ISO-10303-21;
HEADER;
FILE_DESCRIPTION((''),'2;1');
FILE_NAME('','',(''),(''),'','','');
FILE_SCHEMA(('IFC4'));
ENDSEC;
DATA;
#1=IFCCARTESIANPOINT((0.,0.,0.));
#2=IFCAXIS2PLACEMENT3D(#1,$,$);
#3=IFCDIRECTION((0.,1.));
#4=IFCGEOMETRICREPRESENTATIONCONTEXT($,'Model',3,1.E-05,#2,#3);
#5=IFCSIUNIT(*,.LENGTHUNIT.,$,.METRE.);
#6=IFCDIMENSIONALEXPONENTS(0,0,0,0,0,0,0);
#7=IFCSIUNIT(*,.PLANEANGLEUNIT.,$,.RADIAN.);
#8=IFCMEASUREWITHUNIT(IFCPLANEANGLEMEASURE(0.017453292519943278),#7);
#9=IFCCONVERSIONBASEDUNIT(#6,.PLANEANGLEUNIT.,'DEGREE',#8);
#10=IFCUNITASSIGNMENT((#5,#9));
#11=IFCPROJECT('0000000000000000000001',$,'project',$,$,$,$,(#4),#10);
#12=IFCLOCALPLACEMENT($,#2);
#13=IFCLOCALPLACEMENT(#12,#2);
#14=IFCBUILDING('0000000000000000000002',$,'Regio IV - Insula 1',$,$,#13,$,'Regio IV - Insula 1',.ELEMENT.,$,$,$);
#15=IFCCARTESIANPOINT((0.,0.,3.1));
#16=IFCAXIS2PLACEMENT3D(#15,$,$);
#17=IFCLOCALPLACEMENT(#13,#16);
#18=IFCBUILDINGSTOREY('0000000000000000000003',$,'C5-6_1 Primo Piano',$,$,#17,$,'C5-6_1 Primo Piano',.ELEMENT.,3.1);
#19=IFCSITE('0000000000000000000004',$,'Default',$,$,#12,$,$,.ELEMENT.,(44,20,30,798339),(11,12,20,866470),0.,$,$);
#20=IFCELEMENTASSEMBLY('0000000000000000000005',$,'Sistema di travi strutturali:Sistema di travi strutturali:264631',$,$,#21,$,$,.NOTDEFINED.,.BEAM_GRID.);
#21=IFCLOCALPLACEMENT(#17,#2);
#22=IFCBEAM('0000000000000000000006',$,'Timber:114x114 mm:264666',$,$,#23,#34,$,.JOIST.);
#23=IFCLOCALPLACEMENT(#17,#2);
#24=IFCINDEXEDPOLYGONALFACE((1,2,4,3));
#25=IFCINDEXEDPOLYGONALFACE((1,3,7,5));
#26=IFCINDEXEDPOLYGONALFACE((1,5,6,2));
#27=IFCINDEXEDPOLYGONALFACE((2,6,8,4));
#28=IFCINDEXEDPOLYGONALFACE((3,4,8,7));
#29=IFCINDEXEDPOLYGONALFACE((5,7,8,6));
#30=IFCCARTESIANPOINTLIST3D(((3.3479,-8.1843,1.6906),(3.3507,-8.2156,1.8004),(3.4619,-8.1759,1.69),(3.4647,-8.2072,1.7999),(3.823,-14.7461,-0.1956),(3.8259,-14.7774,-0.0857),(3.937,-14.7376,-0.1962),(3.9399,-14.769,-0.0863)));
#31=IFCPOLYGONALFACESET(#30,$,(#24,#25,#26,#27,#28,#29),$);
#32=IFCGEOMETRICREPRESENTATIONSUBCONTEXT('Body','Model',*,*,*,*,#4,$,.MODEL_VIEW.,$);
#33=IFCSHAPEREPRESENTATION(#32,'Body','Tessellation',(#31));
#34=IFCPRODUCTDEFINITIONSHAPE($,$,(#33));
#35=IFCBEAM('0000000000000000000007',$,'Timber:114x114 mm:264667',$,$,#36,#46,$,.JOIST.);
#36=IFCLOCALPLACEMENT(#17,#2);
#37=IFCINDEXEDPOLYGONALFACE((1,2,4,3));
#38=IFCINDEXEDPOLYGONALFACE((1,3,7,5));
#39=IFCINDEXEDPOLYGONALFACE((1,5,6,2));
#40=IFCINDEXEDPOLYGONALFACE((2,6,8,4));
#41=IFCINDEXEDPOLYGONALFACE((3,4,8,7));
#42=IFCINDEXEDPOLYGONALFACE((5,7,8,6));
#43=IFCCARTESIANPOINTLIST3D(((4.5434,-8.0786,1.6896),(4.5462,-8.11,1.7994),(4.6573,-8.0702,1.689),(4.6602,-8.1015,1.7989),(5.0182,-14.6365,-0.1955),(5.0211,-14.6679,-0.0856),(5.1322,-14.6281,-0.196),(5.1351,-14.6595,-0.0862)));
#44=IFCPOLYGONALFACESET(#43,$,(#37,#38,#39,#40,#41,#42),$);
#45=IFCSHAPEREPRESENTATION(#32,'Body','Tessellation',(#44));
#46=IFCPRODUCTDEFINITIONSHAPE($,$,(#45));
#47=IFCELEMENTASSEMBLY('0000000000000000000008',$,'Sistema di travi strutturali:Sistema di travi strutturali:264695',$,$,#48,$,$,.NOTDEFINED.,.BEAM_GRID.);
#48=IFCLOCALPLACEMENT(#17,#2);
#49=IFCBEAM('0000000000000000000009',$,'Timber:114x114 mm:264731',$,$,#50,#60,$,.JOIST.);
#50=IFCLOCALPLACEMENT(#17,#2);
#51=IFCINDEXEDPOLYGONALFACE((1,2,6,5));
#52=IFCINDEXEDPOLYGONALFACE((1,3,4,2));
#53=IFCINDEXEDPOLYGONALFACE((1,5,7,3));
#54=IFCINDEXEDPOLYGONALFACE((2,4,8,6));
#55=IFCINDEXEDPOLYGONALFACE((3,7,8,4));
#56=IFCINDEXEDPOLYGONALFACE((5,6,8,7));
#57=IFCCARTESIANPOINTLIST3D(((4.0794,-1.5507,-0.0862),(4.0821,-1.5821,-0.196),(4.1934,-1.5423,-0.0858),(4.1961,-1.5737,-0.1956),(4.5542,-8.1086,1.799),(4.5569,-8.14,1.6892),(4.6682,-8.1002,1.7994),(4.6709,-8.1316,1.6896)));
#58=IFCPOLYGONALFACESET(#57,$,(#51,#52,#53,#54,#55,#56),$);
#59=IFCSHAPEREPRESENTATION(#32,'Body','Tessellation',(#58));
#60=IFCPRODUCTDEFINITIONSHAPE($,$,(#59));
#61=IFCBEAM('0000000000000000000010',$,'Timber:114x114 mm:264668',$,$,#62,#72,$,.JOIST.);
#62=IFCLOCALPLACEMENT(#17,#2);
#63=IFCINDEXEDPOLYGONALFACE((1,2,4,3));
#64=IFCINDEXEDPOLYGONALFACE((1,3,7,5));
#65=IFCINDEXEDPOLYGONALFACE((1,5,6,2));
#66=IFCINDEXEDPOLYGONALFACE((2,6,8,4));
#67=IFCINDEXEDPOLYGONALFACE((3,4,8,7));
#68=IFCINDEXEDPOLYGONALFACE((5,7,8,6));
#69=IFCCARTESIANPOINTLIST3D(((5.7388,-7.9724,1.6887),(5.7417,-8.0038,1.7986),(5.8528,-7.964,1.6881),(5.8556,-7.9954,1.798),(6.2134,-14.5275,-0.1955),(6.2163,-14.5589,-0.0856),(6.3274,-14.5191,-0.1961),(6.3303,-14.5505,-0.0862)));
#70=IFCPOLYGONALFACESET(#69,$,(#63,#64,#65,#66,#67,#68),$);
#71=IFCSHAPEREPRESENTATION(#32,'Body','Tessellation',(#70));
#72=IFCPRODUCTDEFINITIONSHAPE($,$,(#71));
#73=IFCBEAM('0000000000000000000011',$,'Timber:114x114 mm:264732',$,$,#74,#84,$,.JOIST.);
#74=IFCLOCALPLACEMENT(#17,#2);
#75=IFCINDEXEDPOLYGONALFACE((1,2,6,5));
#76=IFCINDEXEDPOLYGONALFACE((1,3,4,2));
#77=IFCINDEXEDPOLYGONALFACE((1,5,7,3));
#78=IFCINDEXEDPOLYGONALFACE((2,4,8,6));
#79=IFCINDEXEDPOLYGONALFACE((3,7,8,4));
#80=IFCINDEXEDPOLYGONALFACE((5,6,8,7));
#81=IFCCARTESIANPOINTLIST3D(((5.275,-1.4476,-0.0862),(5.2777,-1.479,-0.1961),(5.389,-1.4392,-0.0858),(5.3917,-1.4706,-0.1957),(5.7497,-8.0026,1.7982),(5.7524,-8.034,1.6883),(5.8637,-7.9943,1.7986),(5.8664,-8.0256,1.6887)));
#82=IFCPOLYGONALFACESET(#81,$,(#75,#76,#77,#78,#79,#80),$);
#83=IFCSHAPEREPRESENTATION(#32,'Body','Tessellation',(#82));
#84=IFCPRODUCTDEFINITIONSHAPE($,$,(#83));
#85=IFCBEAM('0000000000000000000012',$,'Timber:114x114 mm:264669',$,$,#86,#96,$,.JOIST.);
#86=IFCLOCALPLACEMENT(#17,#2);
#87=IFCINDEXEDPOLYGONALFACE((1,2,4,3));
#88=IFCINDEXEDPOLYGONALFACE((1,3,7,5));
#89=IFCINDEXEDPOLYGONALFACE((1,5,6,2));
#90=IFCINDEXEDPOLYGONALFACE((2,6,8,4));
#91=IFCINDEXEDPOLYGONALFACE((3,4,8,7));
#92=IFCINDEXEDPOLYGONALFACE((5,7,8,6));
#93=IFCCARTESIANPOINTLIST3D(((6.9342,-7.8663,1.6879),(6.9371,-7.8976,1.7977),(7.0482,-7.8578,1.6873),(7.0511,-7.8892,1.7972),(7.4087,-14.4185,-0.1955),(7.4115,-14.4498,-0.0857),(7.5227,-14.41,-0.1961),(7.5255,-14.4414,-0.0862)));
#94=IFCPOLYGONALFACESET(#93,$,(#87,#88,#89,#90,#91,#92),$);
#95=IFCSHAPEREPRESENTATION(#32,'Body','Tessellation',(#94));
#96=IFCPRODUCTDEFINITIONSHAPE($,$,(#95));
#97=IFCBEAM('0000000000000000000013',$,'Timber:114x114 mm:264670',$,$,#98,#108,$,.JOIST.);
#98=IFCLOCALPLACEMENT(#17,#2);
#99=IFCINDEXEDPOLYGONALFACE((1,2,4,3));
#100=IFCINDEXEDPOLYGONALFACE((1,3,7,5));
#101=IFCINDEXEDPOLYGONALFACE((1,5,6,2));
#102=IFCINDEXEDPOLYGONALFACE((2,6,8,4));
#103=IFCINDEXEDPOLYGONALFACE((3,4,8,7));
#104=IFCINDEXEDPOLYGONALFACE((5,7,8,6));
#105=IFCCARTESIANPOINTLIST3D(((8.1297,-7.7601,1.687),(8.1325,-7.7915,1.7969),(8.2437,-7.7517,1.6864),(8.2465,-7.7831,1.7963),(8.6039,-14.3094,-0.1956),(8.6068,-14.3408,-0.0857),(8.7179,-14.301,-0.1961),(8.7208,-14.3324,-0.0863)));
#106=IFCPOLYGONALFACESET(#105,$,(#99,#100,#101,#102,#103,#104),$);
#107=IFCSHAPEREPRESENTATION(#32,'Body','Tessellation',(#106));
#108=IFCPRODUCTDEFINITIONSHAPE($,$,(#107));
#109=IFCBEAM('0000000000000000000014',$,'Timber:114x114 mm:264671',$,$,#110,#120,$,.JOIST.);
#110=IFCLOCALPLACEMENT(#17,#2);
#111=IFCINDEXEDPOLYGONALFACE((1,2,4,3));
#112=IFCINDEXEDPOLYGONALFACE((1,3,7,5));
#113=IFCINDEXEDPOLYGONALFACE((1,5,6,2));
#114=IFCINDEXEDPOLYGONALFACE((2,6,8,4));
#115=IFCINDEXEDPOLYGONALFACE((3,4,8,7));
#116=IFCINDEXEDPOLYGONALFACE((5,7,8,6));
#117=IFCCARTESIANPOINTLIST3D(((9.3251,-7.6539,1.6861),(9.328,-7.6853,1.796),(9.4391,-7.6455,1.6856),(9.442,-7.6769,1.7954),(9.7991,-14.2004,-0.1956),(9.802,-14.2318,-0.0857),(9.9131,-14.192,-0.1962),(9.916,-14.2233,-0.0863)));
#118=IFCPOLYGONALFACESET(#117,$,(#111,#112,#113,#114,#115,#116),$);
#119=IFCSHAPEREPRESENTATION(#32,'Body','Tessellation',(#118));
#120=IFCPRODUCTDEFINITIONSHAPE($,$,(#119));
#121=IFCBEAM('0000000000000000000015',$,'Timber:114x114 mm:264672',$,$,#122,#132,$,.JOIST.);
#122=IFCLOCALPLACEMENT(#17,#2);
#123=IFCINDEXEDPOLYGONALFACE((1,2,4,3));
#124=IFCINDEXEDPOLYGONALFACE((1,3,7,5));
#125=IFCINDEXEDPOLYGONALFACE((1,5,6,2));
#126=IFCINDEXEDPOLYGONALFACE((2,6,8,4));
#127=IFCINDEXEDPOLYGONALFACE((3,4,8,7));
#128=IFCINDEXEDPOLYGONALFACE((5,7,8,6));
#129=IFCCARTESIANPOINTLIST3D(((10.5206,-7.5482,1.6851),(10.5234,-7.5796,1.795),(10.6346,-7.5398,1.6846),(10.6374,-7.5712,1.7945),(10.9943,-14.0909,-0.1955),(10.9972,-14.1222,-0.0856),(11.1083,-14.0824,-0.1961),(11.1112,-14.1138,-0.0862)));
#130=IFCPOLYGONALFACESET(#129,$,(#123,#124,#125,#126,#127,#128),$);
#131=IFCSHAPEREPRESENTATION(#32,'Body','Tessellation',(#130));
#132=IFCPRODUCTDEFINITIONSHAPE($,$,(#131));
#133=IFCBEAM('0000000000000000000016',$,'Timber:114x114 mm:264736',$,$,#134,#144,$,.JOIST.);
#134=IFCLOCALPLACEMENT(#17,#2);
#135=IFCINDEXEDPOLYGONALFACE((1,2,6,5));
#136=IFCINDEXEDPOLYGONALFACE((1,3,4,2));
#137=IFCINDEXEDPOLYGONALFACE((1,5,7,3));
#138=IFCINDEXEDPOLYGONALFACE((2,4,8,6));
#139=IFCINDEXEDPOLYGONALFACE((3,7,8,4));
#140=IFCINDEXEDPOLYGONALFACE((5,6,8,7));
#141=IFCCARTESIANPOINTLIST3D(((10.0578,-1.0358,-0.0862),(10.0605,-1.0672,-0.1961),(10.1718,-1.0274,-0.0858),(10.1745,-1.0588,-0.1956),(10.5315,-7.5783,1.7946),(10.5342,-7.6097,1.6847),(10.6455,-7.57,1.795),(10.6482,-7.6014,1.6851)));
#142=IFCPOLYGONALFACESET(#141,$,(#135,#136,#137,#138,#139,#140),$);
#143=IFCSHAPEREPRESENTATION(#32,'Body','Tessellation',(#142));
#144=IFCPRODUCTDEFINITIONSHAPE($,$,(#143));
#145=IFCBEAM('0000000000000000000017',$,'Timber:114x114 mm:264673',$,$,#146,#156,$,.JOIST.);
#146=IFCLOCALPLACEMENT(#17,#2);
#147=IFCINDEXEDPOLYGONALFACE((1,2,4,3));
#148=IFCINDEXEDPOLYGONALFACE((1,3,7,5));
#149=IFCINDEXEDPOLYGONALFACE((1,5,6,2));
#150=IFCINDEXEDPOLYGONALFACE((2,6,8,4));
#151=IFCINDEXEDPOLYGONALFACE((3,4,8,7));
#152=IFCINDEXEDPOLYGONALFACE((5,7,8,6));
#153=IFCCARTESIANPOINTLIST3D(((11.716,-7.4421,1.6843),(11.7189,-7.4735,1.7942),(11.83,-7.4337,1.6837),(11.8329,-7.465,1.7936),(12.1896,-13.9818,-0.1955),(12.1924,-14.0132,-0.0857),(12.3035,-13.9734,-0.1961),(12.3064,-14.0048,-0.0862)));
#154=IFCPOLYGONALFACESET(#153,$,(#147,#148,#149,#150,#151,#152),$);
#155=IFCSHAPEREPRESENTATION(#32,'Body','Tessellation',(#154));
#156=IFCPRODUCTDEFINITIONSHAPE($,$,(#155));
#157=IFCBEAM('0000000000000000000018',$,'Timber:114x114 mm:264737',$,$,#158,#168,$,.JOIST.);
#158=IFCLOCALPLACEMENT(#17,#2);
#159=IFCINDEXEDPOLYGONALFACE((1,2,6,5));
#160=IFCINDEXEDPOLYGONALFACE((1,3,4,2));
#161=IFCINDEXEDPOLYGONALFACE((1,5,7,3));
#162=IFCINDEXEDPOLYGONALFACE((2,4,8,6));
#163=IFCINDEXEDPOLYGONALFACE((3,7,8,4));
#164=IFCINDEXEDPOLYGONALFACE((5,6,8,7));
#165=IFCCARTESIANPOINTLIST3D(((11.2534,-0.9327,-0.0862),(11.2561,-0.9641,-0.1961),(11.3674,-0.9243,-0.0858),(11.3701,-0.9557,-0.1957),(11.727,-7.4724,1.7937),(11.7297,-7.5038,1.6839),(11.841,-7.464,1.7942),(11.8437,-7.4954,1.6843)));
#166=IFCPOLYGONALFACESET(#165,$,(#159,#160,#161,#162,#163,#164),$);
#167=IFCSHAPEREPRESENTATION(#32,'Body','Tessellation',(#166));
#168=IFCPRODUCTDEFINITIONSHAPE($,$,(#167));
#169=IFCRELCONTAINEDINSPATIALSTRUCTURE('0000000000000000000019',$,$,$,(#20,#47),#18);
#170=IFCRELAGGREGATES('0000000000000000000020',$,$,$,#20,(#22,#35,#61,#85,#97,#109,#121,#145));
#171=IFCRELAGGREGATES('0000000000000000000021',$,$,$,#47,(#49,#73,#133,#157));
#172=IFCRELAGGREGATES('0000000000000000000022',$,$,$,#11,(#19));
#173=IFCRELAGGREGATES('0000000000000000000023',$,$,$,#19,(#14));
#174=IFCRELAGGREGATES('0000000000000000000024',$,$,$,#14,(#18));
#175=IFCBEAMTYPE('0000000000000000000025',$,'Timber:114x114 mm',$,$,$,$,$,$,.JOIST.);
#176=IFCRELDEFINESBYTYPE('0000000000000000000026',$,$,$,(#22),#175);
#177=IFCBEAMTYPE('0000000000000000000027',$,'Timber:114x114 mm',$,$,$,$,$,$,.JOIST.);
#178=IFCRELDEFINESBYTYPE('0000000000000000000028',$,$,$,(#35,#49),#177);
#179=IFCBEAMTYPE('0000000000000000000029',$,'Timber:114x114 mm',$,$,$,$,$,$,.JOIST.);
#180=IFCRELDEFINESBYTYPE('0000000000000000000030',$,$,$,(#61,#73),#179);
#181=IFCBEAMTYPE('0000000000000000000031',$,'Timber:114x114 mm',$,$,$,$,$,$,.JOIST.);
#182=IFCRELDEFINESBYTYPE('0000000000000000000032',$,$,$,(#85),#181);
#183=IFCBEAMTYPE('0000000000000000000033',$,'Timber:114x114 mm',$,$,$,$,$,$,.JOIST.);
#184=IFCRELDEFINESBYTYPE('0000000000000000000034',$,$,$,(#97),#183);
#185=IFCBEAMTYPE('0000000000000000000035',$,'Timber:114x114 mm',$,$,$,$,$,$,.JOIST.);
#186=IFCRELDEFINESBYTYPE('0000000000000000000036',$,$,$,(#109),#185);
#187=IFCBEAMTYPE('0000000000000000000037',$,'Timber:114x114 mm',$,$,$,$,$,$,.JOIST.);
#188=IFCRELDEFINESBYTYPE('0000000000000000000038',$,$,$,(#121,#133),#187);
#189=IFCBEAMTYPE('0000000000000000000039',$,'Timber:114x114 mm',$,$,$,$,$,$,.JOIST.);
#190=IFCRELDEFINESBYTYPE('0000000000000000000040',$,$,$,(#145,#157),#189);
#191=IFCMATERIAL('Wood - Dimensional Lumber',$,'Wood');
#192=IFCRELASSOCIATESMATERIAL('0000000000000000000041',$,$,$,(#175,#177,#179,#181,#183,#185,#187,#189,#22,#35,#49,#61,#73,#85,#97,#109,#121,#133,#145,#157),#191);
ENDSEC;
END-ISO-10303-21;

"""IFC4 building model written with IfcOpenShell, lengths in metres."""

from ifc_helpers import new_model, entity, si_unit, converted_unit, direction, frame, origin, origin_2d_with_axis, place, context, subcontext, project, spatial, rectangle, extrude, source, transform, mapped, material, material_profile, profile_set, profile_usage, type_object, type_shapes, element, aggregate, save


model = new_model("IFC4")

# Units and contexts
model_context = context("Model", 3, precision=1e-05, world=origin(), true_north=direction((0.0, 1.0)))
body_context = subcontext(model_context, "Body", "Model", "MODEL_VIEW")
ifc_project = project(units=[si_unit("LENGTHUNIT", "METRE"), converted_unit("PLANEANGLEUNIT", "DEGREE", entity("IfcPlaneAngleMeasure", 0.017453292519943278), si_unit("PLANEANGLEUNIT", "RADIAN"), dimensions=[0, 0, 0, 0, 0, 0, 0])], contexts=[model_context])

# Site, building, storey
site_placement = place(None, origin())
site = spatial("IfcSite", under=ifc_project, at=site_placement, Name="Default", CompositionType="ELEMENT", RefLatitude=(44, 20, 30, 798339), RefLongitude=(11, 12, 20, 866470), RefElevation=0.0)
building_placement = place(site_placement, origin())
building = spatial("IfcBuilding", under=site, at=building_placement, Name="Regio IV - Insula 1", LongName="Regio IV - Insula 1", CompositionType="ELEMENT")
storey_placement = place(building_placement, frame((0.0, 0.0, 3.1)))
storey = spatial("IfcBuildingStorey", under=building, at=storey_placement, Name="C5-6_1 Primo Piano", LongName="C5-6_1 Primo Piano", CompositionType="ELEMENT", Elevation=3.1)

# Element assembly, beams
assembly_1_placement = place(storey_placement, origin())
assembly_1 = element("IfcElementAssembly", 1, at=assembly_1_placement, inside=storey, Name="Sistema di travi strutturali:Sistema di travi strutturali:264631", AssemblyPlace="NOTDEFINED", PredefinedType="BEAM_GRID")
ifc_material = material(Name="Wood - Dimensional Lumber", Category="Wood")
ifc_material_profile_1 = material_profile(ifc_material, rectangle(XDim=5.294, YDim=0.1143, at=origin_2d_with_axis()), Name="114x114 mm")
ifc_profile_set_1 = profile_set([ifc_material_profile_1], Name="114x114 mm")
ifc_profile_usage_1 = profile_usage(ifc_profile_set_1, cardinal=8)
beam_type_1 = type_object("IfcBeamType", Name="Timber:114x114 mm", PredefinedType="JOIST", material=ifc_profile_set_1)
shared_shape_1 = source(origin(), body_context, "Body", "SweptSolid", [
    extrude(rectangle(XDim=6.844, YDim=0.1143, at=origin_2d_with_axis()), frame((0.0, 0.0, -0.0572), z_axis=(0.0, 0.0, 1.0), x_axis=(-1.0, 0.0, 0.0)), (0.0, 0.0, 1.0), 0.1143),
])
type_shapes(beam_type_1, [shared_shape_1])
beam_1_placement = place(assembly_1_placement, frame((3.6439, -11.4766, 0.8021), z_axis=(0.025067, -0.274495, 0.961262), x_axis=(0.069423, -0.958764, -0.275592)))
beam_1 = element("IfcBeam", 2, at=beam_1_placement, type_object=beam_type_1, material=ifc_profile_usage_1, Name="Timber:114x114 mm:264666", PredefinedType="JOIST", context=body_context, shape_type="MappedRepresentation", body=[
    mapped(shared_shape_1, transform((0.0, 0.0, 0.0), scale=1.0)),
])
beam_type_2 = type_object("IfcBeamType", Name="Timber:114x114 mm", PredefinedType="JOIST", material=ifc_profile_set_1)
shared_shape_2 = source(origin(), body_context, "Body", "SweptSolid", [
    extrude(rectangle(XDim=6.84, YDim=0.1143, at=origin_2d_with_axis()), frame((0.0, 0.0, -0.0572), z_axis=(0.0, 0.0, 1.0), x_axis=(-1.0, 0.0, 0.0)), (0.0, 0.0, 1.0), 0.1143),
])
type_shapes(beam_type_2, [shared_shape_2])
beam_2_placement = place(assembly_1_placement, frame((4.8392, -11.369, 0.8017), z_axis=(0.025067, -0.274495, 0.961262), x_axis=(0.069423, -0.958764, -0.275592)))
beam_2 = element("IfcBeam", 3, at=beam_2_placement, type_object=beam_type_2, material=ifc_profile_usage_1, Name="Timber:114x114 mm:264667", PredefinedType="JOIST", context=body_context, shape_type="MappedRepresentation", body=[
    mapped(shared_shape_2, transform((0.0, 0.0, 0.0), scale=1.0)),
])

# Element assembly, beam
assembly_2_placement = place(storey_placement, origin())
assembly_2 = element("IfcElementAssembly", 4, at=assembly_2_placement, inside=storey, Name="Sistema di travi strutturali:Sistema di travi strutturali:264695", AssemblyPlace="NOTDEFINED", PredefinedType="BEAM_GRID")
beam_3_placement = place(assembly_2_placement, frame((4.3751, -4.8411, 0.8017), z_axis=(-0.02365, 0.274621, 0.961262), x_axis=(0.069423, -0.958758, 0.275614)))
beam_3 = element("IfcBeam", 5, at=beam_3_placement, type_object=beam_type_2, material=ifc_profile_usage_1, Name="Timber:114x114 mm:264731", PredefinedType="JOIST", context=body_context, shape_type="MappedRepresentation", body=[
    mapped(shared_shape_2, transform((0.0, 0.0, 0.0), scale=1.0)),
])

# Beams
beam_type_3 = type_object("IfcBeamType", Name="Timber:114x114 mm", PredefinedType="JOIST", material=ifc_profile_set_1)
shared_shape_3 = source(origin(), body_context, "Body", "SweptSolid", [
    extrude(rectangle(XDim=6.837, YDim=0.1143, at=origin_2d_with_axis()), frame((0.0, 0.0, -0.0572), z_axis=(0.0, 0.0, 1.0), x_axis=(-1.0, 0.0, 0.0)), (0.0, 0.0, 1.0), 0.1143),
])
type_shapes(beam_type_3, [shared_shape_3])
beam_4_placement = place(assembly_1_placement, frame((6.0345, -11.2614, 0.8013), z_axis=(0.025067, -0.274495, 0.961262), x_axis=(0.069423, -0.958764, -0.275592)))
beam_4 = element("IfcBeam", 6, at=beam_4_placement, type_object=beam_type_3, material=ifc_profile_usage_1, Name="Timber:114x114 mm:264668", PredefinedType="JOIST", context=body_context, shape_type="MappedRepresentation", body=[
    mapped(shared_shape_3, transform((0.0, 0.0, 0.0), scale=1.0)),
])
beam_5_placement = place(assembly_2_placement, frame((5.5707, -4.7366, 0.8013), z_axis=(-0.02365, 0.274621, 0.961262), x_axis=(0.069423, -0.958758, 0.275614)))
beam_5 = element("IfcBeam", 7, at=beam_5_placement, type_object=beam_type_3, material=ifc_profile_usage_1, Name="Timber:114x114 mm:264732", PredefinedType="JOIST", context=body_context, shape_type="MappedRepresentation", body=[
    mapped(shared_shape_3, transform((0.0, 0.0, 0.0), scale=1.0)),
])
beam_type_4 = type_object("IfcBeamType", Name="Timber:114x114 mm", PredefinedType="JOIST", material=ifc_profile_set_1)
shared_shape_4 = source(origin(), body_context, "Body", "SweptSolid", [
    extrude(rectangle(XDim=6.834, YDim=0.1143, at=origin_2d_with_axis()), frame((0.0, 0.0, -0.0572), z_axis=(0.0, 0.0, 1.0), x_axis=(-1.0, 0.0, 0.0)), (0.0, 0.0, 1.0), 0.1143),
])
type_shapes(beam_type_4, [shared_shape_4])
beam_6_placement = place(assembly_1_placement, frame((7.2299, -11.1538, 0.8008), z_axis=(0.025067, -0.274495, 0.961262), x_axis=(0.069423, -0.958764, -0.275592)))
beam_6 = element("IfcBeam", 8, at=beam_6_placement, type_object=beam_type_4, material=ifc_profile_usage_1, Name="Timber:114x114 mm:264669", PredefinedType="JOIST", context=body_context, shape_type="MappedRepresentation", body=[
    mapped(shared_shape_4, transform((0.0, 0.0, 0.0), scale=1.0)),
])
beam_type_5 = type_object("IfcBeamType", Name="Timber:114x114 mm", PredefinedType="JOIST", material=ifc_profile_set_1)
shared_shape_5 = source(origin(), body_context, "Body", "SweptSolid", [
    extrude(rectangle(XDim=6.831, YDim=0.1143, at=origin_2d_with_axis()), frame((0.0, 0.0, -0.0572), z_axis=(0.0, 0.0, 1.0), x_axis=(-1.0, 0.0, 0.0)), (0.0, 0.0, 1.0), 0.1143),
])
type_shapes(beam_type_5, [shared_shape_5])
beam_7_placement = place(assembly_1_placement, frame((8.4252, -11.0462, 0.8004), z_axis=(0.025067, -0.274495, 0.961262), x_axis=(0.069423, -0.958764, -0.275592)))
beam_7 = element("IfcBeam", 9, at=beam_7_placement, type_object=beam_type_5, material=ifc_profile_usage_1, Name="Timber:114x114 mm:264670", PredefinedType="JOIST", context=body_context, shape_type="MappedRepresentation", body=[
    mapped(shared_shape_5, transform((0.0, 0.0, 0.0), scale=1.0)),
])
beam_type_6 = type_object("IfcBeamType", Name="Timber:114x114 mm", PredefinedType="JOIST", material=ifc_profile_set_1)
shared_shape_6 = source(origin(), body_context, "Body", "SweptSolid", [
    extrude(rectangle(XDim=6.828, YDim=0.1143, at=origin_2d_with_axis()), frame((0.0, 0.0, -0.0572), z_axis=(0.0, 0.0, 1.0), x_axis=(-1.0, 0.0, 0.0)), (0.0, 0.0, 1.0), 0.1143),
])
type_shapes(beam_type_6, [shared_shape_6])
beam_8_placement = place(assembly_1_placement, frame((9.6205, -10.9386, 0.7999), z_axis=(0.025067, -0.274495, 0.961262), x_axis=(0.069423, -0.958764, -0.275592)))
beam_8 = element("IfcBeam", 10, at=beam_8_placement, type_object=beam_type_6, material=ifc_profile_usage_1, Name="Timber:114x114 mm:264671", PredefinedType="JOIST", context=body_context, shape_type="MappedRepresentation", body=[
    mapped(shared_shape_6, transform((0.0, 0.0, 0.0), scale=1.0)),
])
beam_type_7 = type_object("IfcBeamType", Name="Timber:114x114 mm", PredefinedType="JOIST", material=ifc_profile_set_1)
shared_shape_7 = source(origin(), body_context, "Body", "SweptSolid", [
    extrude(rectangle(XDim=6.824, YDim=0.1143, at=origin_2d_with_axis()), frame((0.0, 0.0, -0.0572), z_axis=(0.0, 0.0, 1.0), x_axis=(-1.0, 0.0, 0.0)), (0.0, 0.0, 1.0), 0.1143),
])
type_shapes(beam_type_7, [shared_shape_7])
beam_9_placement = place(assembly_1_placement, frame((10.8159, -10.831, 0.7995), z_axis=(0.025067, -0.274495, 0.961262), x_axis=(0.069423, -0.958764, -0.275592)))
beam_9 = element("IfcBeam", 11, at=beam_9_placement, type_object=beam_type_7, material=ifc_profile_usage_1, Name="Timber:114x114 mm:264672", PredefinedType="JOIST", context=body_context, shape_type="MappedRepresentation", body=[
    mapped(shared_shape_7, transform((0.0, 0.0, 0.0), scale=1.0)),
])
beam_10_placement = place(assembly_2_placement, frame((10.353, -4.3186, 0.7995), z_axis=(-0.02365, 0.274621, 0.961262), x_axis=(0.069423, -0.958758, 0.275614)))
beam_10 = element("IfcBeam", 12, at=beam_10_placement, type_object=beam_type_7, material=ifc_profile_usage_1, Name="Timber:114x114 mm:264736", PredefinedType="JOIST", context=body_context, shape_type="MappedRepresentation", body=[
    mapped(shared_shape_7, transform((0.0, 0.0, 0.0), scale=1.0)),
])
beam_type_8 = type_object("IfcBeamType", Name="Timber:114x114 mm", PredefinedType="JOIST", material=ifc_profile_set_1)
shared_shape_8 = source(origin(), body_context, "Body", "SweptSolid", [
    extrude(rectangle(XDim=6.821, YDim=0.1143, at=origin_2d_with_axis()), frame((0.0, 0.0, -0.0572), z_axis=(0.0, 0.0, 1.0), x_axis=(-1.0, 0.0, 0.0)), (0.0, 0.0, 1.0), 0.1143),
])
type_shapes(beam_type_8, [shared_shape_8])
beam_11_placement = place(assembly_1_placement, frame((12.0112, -10.7234, 0.799), z_axis=(0.025067, -0.274495, 0.961262), x_axis=(0.069423, -0.958764, -0.275592)))
beam_11 = element("IfcBeam", 13, at=beam_11_placement, type_object=beam_type_8, material=ifc_profile_usage_1, Name="Timber:114x114 mm:264673", PredefinedType="JOIST", context=body_context, shape_type="MappedRepresentation", body=[
    mapped(shared_shape_8, transform((0.0, 0.0, 0.0), scale=1.0)),
])
beam_12_placement = place(assembly_2_placement, frame((11.5485, -4.214, 0.799), z_axis=(-0.02365, 0.274621, 0.961262), x_axis=(0.069423, -0.958758, 0.275614)))
beam_12 = element("IfcBeam", 14, at=beam_12_placement, type_object=beam_type_8, material=ifc_profile_usage_1, Name="Timber:114x114 mm:264737", PredefinedType="JOIST", context=body_context, shape_type="MappedRepresentation", body=[
    mapped(shared_shape_8, transform((0.0, 0.0, 0.0), scale=1.0)),
])
aggregate(assembly_1, [beam_1, beam_2, beam_4, beam_6, beam_7, beam_8, beam_9, beam_11])
aggregate(assembly_2, [beam_3, beam_5, beam_10, beam_12])

save(model, "model.ifc")
